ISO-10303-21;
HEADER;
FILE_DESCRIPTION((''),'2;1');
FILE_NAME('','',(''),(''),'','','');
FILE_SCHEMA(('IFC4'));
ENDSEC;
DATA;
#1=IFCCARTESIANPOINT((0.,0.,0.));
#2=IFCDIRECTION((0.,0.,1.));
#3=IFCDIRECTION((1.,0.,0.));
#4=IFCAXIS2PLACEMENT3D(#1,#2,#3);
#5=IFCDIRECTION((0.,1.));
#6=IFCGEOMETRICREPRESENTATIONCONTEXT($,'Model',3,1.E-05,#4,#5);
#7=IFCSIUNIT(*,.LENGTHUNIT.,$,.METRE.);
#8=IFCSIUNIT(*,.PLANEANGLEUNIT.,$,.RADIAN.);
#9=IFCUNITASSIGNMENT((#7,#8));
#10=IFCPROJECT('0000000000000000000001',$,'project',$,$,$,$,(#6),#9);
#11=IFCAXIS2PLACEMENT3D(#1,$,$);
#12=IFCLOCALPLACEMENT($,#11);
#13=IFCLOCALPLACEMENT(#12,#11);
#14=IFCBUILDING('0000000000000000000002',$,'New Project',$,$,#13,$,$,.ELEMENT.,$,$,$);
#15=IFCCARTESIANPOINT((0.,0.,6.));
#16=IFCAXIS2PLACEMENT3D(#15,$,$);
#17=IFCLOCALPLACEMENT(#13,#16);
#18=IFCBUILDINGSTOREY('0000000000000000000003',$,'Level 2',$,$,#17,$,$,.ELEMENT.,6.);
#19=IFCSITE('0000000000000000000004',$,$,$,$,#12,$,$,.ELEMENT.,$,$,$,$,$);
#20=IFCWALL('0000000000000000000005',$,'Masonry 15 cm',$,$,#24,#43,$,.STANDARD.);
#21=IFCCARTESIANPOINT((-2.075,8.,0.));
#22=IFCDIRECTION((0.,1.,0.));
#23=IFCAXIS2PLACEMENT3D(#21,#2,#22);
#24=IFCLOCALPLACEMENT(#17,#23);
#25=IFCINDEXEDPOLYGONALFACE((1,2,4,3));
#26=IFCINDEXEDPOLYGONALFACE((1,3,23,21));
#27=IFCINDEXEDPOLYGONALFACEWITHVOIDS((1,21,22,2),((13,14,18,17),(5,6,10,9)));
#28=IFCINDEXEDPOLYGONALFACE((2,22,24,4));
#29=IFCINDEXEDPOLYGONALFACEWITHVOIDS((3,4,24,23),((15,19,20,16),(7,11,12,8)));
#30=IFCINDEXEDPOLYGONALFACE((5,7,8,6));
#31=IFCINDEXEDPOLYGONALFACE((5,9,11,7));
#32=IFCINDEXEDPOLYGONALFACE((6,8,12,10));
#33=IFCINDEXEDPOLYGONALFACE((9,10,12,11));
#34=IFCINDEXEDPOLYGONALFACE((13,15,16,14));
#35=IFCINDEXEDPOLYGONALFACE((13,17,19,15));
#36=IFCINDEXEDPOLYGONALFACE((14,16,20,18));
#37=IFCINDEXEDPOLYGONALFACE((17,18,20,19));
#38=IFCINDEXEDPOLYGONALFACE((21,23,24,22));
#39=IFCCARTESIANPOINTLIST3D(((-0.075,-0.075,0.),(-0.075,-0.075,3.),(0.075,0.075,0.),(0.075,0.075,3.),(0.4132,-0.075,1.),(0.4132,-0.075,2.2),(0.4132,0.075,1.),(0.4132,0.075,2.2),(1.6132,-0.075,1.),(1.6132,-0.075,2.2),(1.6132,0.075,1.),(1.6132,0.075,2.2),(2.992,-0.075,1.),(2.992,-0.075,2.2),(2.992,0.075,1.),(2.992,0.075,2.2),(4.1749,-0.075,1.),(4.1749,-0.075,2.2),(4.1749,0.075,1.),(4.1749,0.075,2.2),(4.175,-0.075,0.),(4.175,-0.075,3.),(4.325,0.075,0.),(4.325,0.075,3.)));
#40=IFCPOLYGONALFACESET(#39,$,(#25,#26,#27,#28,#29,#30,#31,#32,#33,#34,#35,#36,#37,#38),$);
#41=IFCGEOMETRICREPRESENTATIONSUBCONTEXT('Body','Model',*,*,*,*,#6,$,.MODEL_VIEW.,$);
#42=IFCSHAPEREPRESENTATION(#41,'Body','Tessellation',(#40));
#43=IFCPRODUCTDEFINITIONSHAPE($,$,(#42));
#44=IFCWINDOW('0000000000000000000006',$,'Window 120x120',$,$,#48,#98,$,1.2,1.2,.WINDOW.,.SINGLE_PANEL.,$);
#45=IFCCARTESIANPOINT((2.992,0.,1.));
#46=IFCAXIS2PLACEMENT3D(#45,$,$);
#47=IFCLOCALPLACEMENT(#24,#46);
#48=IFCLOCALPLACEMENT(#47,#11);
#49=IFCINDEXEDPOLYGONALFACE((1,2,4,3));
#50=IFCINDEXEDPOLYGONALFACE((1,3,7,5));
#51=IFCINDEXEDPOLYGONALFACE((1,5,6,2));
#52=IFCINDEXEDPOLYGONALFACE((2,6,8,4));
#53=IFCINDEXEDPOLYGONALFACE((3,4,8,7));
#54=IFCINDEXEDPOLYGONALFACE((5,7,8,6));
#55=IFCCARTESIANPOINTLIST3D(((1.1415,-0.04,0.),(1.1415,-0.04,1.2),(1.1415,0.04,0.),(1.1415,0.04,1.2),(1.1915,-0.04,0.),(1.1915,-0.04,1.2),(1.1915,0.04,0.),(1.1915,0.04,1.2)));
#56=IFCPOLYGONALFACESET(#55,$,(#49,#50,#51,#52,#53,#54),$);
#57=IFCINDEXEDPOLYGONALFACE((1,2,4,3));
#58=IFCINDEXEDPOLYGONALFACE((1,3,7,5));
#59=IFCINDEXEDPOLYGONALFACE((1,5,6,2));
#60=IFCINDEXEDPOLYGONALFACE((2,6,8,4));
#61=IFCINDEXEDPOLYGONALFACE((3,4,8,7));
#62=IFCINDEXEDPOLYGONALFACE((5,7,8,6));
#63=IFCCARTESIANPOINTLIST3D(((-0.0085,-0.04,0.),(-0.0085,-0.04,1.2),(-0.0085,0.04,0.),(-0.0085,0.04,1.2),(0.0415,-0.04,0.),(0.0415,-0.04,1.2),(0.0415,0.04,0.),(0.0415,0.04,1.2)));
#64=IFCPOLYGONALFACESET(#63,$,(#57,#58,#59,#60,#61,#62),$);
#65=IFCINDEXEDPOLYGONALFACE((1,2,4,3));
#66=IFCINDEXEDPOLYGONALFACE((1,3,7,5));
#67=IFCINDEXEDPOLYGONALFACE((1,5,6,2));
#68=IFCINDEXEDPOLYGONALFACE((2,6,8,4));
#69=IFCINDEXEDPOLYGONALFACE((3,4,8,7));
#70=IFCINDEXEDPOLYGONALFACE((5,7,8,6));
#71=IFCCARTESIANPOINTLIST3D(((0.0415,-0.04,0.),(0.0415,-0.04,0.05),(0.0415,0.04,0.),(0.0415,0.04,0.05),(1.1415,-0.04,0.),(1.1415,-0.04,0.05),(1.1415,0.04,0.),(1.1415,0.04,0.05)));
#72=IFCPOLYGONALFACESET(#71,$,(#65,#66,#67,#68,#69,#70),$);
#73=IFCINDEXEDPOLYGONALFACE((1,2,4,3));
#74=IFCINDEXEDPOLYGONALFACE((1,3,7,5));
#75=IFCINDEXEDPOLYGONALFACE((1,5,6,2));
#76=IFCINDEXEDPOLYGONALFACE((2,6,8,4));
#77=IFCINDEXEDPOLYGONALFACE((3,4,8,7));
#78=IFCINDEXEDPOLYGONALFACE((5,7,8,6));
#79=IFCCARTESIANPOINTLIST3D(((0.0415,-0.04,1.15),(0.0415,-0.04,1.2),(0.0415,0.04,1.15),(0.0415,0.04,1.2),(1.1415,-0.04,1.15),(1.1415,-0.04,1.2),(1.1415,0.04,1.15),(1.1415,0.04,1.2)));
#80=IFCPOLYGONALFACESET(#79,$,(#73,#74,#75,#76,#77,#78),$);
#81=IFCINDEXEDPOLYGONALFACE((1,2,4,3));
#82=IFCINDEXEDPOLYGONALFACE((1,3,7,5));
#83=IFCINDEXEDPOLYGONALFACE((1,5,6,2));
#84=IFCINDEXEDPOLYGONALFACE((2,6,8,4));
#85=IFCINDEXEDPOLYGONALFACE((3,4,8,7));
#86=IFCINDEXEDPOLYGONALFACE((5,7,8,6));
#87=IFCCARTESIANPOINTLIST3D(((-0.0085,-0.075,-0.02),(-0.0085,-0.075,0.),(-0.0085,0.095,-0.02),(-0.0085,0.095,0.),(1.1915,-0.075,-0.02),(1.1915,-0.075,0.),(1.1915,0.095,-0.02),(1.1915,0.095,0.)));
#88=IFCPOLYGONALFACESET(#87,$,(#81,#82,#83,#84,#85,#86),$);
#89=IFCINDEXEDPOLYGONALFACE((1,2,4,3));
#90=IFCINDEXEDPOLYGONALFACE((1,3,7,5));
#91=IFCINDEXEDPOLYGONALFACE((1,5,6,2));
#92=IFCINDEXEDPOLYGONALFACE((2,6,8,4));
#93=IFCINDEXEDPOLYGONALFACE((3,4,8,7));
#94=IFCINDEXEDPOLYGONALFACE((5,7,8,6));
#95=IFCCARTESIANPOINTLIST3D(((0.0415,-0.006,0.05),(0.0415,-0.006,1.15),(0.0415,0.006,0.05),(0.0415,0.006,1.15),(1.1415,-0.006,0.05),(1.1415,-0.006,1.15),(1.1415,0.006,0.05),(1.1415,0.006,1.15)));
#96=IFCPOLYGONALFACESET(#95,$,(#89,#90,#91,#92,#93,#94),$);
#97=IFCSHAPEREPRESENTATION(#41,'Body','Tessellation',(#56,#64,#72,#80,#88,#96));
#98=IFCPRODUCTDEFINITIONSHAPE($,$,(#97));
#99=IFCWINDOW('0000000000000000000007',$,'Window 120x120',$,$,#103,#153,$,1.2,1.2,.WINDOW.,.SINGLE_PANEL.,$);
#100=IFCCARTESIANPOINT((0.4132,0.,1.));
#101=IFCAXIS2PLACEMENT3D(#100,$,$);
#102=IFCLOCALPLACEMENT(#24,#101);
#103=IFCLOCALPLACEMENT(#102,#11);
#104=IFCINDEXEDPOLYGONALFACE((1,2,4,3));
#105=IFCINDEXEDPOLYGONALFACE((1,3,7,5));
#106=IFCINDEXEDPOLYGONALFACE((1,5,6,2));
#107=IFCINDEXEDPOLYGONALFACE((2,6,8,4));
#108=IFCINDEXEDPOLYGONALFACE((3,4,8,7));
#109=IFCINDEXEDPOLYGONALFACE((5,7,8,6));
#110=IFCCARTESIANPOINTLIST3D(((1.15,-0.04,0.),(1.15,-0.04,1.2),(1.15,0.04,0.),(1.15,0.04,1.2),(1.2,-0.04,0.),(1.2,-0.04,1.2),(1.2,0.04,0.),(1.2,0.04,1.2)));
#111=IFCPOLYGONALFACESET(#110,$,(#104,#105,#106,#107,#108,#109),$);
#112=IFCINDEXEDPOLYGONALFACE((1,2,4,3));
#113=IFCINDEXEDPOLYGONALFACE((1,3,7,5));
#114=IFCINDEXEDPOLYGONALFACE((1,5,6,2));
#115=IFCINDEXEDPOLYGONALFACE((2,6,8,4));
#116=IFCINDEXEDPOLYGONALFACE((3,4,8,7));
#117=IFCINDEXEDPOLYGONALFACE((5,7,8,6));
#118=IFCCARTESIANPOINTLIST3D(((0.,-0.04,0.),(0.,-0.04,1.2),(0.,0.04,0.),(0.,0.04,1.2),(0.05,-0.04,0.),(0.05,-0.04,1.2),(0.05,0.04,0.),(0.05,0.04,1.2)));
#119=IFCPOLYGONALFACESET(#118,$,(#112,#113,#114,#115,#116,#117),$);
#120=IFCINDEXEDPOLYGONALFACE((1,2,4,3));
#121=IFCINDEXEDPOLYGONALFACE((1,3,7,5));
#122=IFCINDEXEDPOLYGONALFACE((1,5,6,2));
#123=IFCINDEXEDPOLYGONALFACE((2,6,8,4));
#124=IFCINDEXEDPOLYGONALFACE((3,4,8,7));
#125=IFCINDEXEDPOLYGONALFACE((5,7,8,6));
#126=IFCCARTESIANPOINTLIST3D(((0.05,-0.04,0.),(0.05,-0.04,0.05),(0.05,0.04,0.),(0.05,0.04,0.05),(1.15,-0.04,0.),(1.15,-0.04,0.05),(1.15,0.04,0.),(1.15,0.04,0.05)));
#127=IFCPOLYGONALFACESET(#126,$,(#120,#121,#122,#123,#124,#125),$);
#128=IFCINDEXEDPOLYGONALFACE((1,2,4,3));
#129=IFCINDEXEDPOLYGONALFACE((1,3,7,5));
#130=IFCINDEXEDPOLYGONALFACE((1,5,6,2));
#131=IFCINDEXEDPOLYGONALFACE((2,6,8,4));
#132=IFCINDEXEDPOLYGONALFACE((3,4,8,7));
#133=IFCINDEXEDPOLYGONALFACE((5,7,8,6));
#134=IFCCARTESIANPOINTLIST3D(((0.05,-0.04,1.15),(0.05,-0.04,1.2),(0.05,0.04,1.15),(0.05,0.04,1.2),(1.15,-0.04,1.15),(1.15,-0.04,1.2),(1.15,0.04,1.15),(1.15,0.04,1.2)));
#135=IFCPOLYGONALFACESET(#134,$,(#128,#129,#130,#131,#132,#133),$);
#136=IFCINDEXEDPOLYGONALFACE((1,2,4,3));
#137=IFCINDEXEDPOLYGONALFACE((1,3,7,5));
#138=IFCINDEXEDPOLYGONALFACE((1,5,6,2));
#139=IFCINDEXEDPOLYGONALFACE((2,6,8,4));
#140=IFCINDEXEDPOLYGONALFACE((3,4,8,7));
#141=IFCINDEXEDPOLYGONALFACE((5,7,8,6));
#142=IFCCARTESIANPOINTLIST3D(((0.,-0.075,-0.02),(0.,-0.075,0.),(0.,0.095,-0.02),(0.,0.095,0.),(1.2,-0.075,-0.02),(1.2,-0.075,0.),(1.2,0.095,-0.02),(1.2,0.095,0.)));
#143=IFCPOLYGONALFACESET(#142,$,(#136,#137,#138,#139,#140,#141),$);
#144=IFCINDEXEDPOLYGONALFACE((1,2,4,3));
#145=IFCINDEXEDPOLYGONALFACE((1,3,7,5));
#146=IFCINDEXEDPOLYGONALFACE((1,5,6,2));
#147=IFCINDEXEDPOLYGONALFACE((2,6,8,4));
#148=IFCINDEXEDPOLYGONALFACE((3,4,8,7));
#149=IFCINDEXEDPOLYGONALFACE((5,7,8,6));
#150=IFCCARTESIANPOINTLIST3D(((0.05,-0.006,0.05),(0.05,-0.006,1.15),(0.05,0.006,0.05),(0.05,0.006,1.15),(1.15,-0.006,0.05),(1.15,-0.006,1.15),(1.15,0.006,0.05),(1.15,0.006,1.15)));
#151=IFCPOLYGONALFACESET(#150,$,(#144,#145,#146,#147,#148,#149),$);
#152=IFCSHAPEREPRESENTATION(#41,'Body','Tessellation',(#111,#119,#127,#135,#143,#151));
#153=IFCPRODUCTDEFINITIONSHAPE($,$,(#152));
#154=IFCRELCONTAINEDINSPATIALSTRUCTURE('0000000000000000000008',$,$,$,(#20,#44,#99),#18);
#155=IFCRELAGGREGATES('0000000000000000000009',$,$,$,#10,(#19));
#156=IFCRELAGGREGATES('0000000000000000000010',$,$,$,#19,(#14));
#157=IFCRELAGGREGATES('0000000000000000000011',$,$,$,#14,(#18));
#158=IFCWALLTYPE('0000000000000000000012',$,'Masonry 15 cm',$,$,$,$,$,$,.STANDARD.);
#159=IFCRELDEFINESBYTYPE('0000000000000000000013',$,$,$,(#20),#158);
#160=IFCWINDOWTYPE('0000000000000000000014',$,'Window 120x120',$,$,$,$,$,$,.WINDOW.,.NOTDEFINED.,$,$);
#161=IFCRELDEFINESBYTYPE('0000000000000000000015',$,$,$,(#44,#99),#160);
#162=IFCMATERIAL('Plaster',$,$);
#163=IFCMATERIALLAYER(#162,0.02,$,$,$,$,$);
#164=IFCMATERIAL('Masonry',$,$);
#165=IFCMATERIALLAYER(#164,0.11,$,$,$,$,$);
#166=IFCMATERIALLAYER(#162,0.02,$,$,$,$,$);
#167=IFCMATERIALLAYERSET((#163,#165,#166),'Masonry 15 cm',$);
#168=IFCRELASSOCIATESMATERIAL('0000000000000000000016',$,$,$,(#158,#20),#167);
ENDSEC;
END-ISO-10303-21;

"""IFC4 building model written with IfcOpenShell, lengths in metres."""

from ifc_helpers import new_model, si_unit, direction, frame, frame_2d, origin, origin_with_axes, place, context, subcontext, project, spatial, polyline, rectangle, outline, extrude, material, layer, layer_set, layer_usage, type_object, element, fill, save


model = new_model("IFC4")

# Units and contexts
model_context = context("Model", 3, precision=1e-05, world=origin_with_axes(), true_north=direction((0.0, 1.0)))
body_context = subcontext(model_context, "Body", "Model", "MODEL_VIEW")
ifc_project = project(units=[si_unit("LENGTHUNIT", "METRE"), si_unit("PLANEANGLEUNIT", "RADIAN")], contexts=[model_context])

# Site, building, storey
site_placement = place(None, origin())
site = spatial("IfcSite", under=ifc_project, at=site_placement, CompositionType="ELEMENT")
building_placement = place(site_placement, origin())
building = spatial("IfcBuilding", under=site, at=building_placement, Name="New Project", CompositionType="ELEMENT")
storey_placement = place(building_placement, frame((0.0, 0.0, 6.0)))
storey = spatial("IfcBuildingStorey", under=building, at=storey_placement, Name="Level 2", CompositionType="ELEMENT", Elevation=6.0)

# Shared definitions
ifc_material_1 = material(Name="Plaster")
ifc_layer_1 = layer(ifc_material_1, 0.02)
ifc_material_2 = material(Name="Masonry")
ifc_layer_2 = layer(ifc_material_2, 0.11)
ifc_layer_3 = layer(ifc_material_1, 0.02)
ifc_layer_set_1 = layer_set([ifc_layer_1, ifc_layer_2, ifc_layer_3], Name="Masonry 15 cm")
ifc_layer_usage_1 = layer_usage(ifc_layer_set_1, "AXIS2", "NEGATIVE", 0.075)
wall_type = type_object("IfcWallType", Name="Masonry 15 cm", PredefinedType="STANDARD", material=ifc_layer_set_1)
window_type = type_object("IfcWindowType", Name="Window 120x120", PartitioningType="NOTDEFINED", PredefinedType="WINDOW")

# Wall, openings, windows
wall_1_placement = place(storey_placement, frame((-2.075, 8.0, 0.0), z_axis=(0.0, 0.0, 1.0), x_axis=(0.0, 1.0, 0.0)))
wall_1 = element("IfcWall", 1, at=wall_1_placement, inside=storey, type_object=wall_type, material=ifc_layer_usage_1, Name="Masonry 15 cm", PredefinedType="STANDARD", context=body_context, shape_type="SweptSolid", body=[
    extrude(outline(polyline([(-0.075, -0.075), (4.175, -0.075), (4.325, 0.075), (0.075, 0.075), (-0.075, -0.075)])), origin(), (0.0, 0.0, 1.0), 3.0),
])
opening_1_placement = place(wall_1_placement, frame((2.992, 0.0, 1.0)))
opening_1 = element("IfcOpeningElement", 2, at=opening_1_placement, cuts=wall_1, PredefinedType="OPENING", context=body_context, shape_type="SweptSolid", body=[
    extrude(rectangle(XDim=1.1829, YDim=0.25, at=frame_2d((0.5915, 0.0))), origin(), (0.0, 0.0, 1.0), 1.2),
])
opening_2_placement = place(wall_1_placement, frame((0.4132, 0.0, 1.0)))
opening_2 = element("IfcOpeningElement", 3, at=opening_2_placement, cuts=wall_1, PredefinedType="OPENING", context=body_context, shape_type="SweptSolid", body=[
    extrude(rectangle(XDim=1.2, YDim=0.25, at=frame_2d((0.6, 0.0))), origin(), (0.0, 0.0, 1.0), 1.2),
])
window_1_placement = place(opening_1_placement, origin())
window_1 = element("IfcWindow", 4, at=window_1_placement, inside=storey, type_object=window_type, Name="Window 120x120", OverallHeight=1.2, OverallWidth=1.2, PartitioningType="SINGLE_PANEL", PredefinedType="WINDOW", context=body_context, shape_type="SweptSolid", body=[
    extrude(outline(polyline([(1.1915, 0.04), (1.1415, 0.04), (1.1415, -0.04), (1.1915, -0.04), (1.1915, 0.04)])), origin(), (0.0, 0.0, 1.0), 1.2),
    extrude(outline(polyline([(0.0415, 0.04), (-0.0085, 0.04), (-0.0085, -0.04), (0.0415, -0.04), (0.0415, 0.04)])), origin(), (0.0, 0.0, 1.0), 1.2),
    extrude(outline(polyline([(1.1415, 0.04), (0.0415, 0.04), (0.0415, -0.04), (1.1415, -0.04), (1.1415, 0.04)])), origin(), (0.0, 0.0, 1.0), 0.05),
    extrude(outline(polyline([(1.1415, 0.04), (0.0415, 0.04), (0.0415, -0.04), (1.1415, -0.04), (1.1415, 0.04)])), frame((0.0, 0.0, 1.15)), (0.0, 0.0, 1.0), 0.05),
    extrude(outline(polyline([(1.1915, 0.095), (-0.0085, 0.095), (-0.0085, -0.075), (1.1915, -0.075), (1.1915, 0.095)])), frame((0.0, 0.0, -0.02)), (0.0, 0.0, 1.0), 0.02),
    extrude(outline(polyline([(1.1415, 0.006), (0.0415, 0.006), (0.0415, -0.006), (1.1415, -0.006), (1.1415, 0.006)])), frame((0.0, 0.0, 0.05)), (0.0, 0.0, 1.0), 1.1),
])
fill(opening_1, window_1)
window_2_placement = place(opening_2_placement, origin())
window_2 = element("IfcWindow", 5, at=window_2_placement, inside=storey, type_object=window_type, Name="Window 120x120", OverallHeight=1.2, OverallWidth=1.2, PartitioningType="SINGLE_PANEL", PredefinedType="WINDOW", context=body_context, shape_type="SweptSolid", body=[
    extrude(outline(polyline([(1.2, 0.04), (1.15, 0.04), (1.15, -0.04), (1.2, -0.04), (1.2, 0.04)])), origin(), (0.0, 0.0, 1.0), 1.2),
    extrude(outline(polyline([(0.05, 0.04), (0.0, 0.04), (0.0, -0.04), (0.05, -0.04), (0.05, 0.04)])), origin(), (0.0, 0.0, 1.0), 1.2),
    extrude(outline(polyline([(1.15, 0.04), (0.05, 0.04), (0.05, -0.04), (1.15, -0.04), (1.15, 0.04)])), origin(), (0.0, 0.0, 1.0), 0.05),
    extrude(outline(polyline([(1.15, 0.04), (0.05, 0.04), (0.05, -0.04), (1.15, -0.04), (1.15, 0.04)])), frame((0.0, 0.0, 1.15)), (0.0, 0.0, 1.0), 0.05),
    extrude(outline(polyline([(1.2, 0.095), (0.0, 0.095), (0.0, -0.075), (1.2, -0.075), (1.2, 0.095)])), frame((0.0, 0.0, -0.02)), (0.0, 0.0, 1.0), 0.02),
    extrude(outline(polyline([(1.15, 0.006), (0.05, 0.006), (0.05, -0.006), (1.15, -0.006), (1.15, 0.006)])), frame((0.0, 0.0, 0.05)), (0.0, 0.0, 1.0), 1.1),
])
fill(opening_2, window_2)

save(model, "model.ifc")
